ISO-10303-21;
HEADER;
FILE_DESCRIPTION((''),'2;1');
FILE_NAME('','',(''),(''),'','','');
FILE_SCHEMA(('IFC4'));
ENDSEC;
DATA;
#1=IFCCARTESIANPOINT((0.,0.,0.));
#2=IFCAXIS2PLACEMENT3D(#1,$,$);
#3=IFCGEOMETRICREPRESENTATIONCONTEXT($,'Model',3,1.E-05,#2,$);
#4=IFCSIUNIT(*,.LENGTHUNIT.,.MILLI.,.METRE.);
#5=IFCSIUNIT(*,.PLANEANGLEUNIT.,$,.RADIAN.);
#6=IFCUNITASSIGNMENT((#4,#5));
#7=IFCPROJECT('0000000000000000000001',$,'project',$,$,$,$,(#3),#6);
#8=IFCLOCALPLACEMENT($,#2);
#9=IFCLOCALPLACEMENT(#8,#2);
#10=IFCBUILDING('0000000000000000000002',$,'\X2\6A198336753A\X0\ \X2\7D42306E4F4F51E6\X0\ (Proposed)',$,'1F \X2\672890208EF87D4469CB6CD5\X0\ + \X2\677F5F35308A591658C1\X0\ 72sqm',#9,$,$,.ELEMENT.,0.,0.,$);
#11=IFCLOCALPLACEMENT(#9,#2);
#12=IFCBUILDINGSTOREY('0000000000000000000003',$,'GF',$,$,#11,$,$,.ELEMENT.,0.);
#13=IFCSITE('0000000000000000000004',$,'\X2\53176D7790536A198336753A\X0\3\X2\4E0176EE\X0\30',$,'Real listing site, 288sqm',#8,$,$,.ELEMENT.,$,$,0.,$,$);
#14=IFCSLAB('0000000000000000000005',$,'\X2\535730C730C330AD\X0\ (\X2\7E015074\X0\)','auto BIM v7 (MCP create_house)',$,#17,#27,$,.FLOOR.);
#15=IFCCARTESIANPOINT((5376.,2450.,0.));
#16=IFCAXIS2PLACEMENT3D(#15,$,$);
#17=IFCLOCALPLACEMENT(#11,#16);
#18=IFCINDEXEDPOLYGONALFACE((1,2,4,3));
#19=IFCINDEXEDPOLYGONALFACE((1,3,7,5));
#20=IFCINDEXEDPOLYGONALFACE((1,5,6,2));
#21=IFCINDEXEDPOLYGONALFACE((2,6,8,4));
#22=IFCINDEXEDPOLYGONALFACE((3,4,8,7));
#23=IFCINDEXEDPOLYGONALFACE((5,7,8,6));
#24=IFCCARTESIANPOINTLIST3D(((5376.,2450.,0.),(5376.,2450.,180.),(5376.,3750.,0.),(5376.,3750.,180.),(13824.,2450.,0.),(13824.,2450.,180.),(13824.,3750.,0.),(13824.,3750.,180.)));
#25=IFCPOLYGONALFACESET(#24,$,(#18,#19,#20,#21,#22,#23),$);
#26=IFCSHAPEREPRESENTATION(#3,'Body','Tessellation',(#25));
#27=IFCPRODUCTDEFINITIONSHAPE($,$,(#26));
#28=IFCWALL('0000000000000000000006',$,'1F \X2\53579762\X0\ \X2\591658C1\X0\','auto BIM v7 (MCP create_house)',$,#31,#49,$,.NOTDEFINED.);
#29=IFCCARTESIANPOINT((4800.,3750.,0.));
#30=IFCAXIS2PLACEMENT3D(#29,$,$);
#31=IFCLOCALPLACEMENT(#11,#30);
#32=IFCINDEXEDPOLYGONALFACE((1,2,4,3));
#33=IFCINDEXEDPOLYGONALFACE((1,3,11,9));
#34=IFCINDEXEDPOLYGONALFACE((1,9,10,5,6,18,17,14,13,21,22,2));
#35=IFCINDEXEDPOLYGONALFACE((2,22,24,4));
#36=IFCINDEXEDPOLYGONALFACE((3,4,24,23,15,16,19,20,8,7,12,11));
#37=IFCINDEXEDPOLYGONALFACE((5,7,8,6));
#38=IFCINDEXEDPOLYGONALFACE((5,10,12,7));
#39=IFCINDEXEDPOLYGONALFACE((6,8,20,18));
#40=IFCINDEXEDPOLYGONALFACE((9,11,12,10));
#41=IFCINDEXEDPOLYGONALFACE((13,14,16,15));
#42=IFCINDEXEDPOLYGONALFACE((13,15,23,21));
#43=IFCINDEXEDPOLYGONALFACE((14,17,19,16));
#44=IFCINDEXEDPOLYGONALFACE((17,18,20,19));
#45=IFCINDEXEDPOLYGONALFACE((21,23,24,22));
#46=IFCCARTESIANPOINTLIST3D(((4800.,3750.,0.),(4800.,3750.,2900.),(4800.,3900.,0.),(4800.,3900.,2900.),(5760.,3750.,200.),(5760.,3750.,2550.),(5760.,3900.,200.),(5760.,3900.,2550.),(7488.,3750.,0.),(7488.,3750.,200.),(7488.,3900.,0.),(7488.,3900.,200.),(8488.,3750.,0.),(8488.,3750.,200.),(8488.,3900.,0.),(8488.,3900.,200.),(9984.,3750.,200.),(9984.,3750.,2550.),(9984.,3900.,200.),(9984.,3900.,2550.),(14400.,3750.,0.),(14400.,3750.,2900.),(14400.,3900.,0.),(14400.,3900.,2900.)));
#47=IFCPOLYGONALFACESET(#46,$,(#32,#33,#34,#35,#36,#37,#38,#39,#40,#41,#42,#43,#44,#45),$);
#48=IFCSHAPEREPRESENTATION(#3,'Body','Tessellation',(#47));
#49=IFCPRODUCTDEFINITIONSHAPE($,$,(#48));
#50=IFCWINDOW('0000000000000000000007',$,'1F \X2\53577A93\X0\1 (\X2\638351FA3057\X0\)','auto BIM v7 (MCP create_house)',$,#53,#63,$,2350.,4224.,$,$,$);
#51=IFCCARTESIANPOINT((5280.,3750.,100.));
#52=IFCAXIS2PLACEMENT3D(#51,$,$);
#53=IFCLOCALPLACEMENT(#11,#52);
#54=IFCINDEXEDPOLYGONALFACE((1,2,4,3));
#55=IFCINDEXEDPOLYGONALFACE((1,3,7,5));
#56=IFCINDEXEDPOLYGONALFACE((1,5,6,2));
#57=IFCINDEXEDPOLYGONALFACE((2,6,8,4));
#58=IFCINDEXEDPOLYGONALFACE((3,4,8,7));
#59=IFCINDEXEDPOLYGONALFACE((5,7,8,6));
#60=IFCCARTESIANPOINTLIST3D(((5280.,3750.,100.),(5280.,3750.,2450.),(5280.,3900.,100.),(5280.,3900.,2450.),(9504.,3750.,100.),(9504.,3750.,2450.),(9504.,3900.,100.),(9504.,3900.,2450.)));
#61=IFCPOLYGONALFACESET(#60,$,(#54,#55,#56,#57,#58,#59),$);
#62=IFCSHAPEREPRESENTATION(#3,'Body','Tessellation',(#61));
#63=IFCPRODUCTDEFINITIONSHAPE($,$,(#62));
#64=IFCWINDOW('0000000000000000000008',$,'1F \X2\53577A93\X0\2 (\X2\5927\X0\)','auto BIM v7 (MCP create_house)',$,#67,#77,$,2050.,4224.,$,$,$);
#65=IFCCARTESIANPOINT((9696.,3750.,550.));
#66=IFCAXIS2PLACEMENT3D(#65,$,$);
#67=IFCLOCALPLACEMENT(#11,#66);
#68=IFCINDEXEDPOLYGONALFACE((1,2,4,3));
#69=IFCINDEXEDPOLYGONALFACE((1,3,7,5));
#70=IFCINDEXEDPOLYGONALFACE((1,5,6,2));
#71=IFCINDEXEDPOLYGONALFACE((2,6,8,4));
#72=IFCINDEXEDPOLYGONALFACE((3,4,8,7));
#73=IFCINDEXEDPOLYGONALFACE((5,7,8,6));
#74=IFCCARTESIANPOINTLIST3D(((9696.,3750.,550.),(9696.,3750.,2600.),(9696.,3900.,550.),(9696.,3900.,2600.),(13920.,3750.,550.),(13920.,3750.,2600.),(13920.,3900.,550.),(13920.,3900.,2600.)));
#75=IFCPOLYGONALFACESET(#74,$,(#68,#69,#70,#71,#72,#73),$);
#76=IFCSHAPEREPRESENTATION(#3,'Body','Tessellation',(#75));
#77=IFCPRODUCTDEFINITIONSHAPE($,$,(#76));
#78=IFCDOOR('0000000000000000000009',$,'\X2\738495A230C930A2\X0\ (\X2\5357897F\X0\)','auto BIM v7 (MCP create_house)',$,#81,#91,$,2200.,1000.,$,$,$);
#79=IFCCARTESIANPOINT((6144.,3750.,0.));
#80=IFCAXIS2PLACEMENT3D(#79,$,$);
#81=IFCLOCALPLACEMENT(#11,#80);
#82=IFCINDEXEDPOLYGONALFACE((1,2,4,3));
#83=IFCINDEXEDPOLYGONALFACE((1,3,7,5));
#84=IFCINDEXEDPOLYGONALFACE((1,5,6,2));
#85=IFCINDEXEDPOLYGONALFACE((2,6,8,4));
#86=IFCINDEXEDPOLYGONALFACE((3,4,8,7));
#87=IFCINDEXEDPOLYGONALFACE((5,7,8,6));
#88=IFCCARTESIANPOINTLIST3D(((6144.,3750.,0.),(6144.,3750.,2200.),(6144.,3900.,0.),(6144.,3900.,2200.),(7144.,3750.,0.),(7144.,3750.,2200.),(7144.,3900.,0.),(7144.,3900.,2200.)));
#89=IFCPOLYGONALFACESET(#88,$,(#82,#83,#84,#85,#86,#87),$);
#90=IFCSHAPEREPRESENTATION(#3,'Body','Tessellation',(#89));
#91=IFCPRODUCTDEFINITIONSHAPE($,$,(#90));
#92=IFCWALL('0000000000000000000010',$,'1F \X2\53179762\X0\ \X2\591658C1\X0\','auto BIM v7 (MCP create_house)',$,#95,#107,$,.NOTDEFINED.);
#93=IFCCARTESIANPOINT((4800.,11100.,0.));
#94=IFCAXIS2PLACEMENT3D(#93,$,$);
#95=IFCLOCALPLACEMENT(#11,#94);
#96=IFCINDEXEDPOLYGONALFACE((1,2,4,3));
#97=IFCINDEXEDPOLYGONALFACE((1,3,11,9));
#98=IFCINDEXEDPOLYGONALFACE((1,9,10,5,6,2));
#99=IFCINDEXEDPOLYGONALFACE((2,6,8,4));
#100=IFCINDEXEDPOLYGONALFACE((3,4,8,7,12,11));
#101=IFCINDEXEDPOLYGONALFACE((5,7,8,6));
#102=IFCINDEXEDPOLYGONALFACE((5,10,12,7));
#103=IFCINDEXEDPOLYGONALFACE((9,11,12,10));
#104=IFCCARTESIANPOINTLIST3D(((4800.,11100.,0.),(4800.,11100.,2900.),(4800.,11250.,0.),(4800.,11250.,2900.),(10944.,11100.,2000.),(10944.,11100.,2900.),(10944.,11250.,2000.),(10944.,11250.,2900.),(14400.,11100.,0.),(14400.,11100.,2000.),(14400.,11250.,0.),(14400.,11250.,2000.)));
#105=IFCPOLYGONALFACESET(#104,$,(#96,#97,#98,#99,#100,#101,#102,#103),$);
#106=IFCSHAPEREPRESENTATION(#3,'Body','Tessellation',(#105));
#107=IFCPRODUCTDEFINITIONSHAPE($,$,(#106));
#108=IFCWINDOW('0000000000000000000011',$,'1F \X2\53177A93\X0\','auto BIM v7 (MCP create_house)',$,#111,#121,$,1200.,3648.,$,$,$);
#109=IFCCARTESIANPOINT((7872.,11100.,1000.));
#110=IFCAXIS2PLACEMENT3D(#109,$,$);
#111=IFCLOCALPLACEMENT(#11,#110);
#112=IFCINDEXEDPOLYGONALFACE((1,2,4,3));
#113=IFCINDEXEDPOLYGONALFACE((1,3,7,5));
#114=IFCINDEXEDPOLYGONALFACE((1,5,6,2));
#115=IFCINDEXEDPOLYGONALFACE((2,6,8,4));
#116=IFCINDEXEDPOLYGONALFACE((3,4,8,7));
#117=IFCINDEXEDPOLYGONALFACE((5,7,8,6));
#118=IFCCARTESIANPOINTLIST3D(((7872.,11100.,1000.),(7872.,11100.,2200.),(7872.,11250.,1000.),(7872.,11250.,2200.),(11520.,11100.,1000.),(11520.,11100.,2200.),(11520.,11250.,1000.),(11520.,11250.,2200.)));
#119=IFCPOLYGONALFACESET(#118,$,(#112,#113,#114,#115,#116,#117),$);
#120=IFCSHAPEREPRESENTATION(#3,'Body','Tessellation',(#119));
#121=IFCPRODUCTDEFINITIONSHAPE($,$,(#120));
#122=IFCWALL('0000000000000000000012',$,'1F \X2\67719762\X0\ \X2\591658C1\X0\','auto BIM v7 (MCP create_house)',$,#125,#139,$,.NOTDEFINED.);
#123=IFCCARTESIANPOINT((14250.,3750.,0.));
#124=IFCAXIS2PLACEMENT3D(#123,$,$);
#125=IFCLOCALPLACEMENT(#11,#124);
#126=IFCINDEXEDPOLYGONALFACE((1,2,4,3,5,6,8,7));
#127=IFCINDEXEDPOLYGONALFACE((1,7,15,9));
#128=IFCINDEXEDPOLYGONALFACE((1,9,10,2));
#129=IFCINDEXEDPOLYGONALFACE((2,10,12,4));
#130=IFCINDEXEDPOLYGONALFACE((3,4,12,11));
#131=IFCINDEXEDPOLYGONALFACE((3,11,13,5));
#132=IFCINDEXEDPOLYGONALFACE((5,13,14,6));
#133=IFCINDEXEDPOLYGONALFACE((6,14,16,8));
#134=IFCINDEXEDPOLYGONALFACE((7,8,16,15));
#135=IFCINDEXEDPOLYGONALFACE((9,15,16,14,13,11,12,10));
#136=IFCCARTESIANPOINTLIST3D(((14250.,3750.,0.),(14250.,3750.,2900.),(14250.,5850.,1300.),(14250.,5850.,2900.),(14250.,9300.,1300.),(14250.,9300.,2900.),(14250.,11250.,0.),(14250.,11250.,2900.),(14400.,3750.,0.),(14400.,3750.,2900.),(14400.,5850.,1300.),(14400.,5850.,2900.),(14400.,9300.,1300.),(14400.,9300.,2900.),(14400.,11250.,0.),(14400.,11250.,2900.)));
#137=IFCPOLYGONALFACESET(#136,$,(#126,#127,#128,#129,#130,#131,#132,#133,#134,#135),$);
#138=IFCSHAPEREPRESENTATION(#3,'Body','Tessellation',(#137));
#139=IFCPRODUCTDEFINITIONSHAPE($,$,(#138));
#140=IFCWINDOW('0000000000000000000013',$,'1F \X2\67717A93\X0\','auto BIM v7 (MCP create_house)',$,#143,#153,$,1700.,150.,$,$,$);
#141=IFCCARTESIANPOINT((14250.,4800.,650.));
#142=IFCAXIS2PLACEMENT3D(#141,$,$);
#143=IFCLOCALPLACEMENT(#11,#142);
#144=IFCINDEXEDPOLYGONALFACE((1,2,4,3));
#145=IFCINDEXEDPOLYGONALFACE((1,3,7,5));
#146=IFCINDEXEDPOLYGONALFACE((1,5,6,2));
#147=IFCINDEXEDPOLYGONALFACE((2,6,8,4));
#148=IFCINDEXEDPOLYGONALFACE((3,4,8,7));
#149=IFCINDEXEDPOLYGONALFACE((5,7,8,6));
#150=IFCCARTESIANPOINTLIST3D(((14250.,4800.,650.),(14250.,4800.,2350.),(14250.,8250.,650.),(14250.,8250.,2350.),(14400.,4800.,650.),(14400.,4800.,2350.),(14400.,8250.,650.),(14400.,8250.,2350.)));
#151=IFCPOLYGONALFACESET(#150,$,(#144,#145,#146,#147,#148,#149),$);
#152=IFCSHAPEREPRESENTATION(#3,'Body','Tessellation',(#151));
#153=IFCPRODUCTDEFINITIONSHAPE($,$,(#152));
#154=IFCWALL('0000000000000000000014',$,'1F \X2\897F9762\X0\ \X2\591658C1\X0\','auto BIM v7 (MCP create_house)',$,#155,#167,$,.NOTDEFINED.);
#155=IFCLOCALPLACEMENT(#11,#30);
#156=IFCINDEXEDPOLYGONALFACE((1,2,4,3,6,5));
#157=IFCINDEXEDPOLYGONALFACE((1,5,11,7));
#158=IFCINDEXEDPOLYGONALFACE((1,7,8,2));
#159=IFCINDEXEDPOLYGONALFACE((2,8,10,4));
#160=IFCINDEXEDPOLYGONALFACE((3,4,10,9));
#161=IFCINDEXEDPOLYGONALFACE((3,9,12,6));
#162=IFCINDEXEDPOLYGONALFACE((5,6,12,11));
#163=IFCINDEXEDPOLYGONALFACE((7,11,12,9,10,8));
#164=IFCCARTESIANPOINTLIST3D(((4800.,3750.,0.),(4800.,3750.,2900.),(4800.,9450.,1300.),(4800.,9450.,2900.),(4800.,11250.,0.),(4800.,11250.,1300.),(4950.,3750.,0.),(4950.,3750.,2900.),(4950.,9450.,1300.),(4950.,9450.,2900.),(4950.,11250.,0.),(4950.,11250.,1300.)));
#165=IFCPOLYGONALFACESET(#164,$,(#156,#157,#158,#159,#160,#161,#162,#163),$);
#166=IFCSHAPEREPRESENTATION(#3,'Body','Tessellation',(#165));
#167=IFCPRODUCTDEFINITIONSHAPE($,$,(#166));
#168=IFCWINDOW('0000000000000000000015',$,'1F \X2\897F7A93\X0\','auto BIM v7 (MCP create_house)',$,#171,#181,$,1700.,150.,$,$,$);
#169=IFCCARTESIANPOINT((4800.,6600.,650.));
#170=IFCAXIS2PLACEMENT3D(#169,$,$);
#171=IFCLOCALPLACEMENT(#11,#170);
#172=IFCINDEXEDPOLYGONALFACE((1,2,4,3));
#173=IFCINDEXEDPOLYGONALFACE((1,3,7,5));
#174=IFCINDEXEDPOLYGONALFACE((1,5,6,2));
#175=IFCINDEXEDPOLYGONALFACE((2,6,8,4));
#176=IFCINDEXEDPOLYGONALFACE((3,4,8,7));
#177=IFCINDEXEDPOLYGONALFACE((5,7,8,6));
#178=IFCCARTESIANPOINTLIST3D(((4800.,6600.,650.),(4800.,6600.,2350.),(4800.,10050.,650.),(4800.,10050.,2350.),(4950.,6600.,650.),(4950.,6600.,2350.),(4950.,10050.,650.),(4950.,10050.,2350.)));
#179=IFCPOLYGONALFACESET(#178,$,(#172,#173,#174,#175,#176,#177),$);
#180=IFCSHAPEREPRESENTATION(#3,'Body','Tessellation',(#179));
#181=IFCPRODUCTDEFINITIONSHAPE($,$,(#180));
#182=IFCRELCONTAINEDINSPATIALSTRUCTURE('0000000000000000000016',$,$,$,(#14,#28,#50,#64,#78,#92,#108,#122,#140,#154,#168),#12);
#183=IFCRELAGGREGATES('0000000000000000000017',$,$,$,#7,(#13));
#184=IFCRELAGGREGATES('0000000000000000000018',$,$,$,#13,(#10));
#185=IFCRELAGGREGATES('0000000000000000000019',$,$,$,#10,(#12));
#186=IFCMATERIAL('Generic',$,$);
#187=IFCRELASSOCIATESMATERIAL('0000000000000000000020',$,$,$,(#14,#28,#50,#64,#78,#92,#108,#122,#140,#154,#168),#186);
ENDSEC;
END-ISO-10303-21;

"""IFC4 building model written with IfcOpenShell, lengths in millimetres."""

from ifc_helpers import new_model, si_unit, frame, frame_2d, origin, place, context, project, spatial, rectangle, extrude, material, element, fill, save


model = new_model("IFC4")

# Units and contexts
model_context = context("Model", 3, precision=1e-05, world=origin())
ifc_project = project(units=[si_unit("LENGTHUNIT", "METRE", prefix="MILLI"), si_unit("PLANEANGLEUNIT", "RADIAN")], contexts=[model_context])

# Site, building, storey
site_placement = place(None, origin())
site = spatial("IfcSite", under=ifc_project, at=site_placement, Name="北海道標茶町3丁目30", ObjectType="Real listing site, 288sqm", CompositionType="ELEMENT", RefElevation=0.0)
building_placement = place(site_placement, origin())
building = spatial("IfcBuilding", under=site, at=building_placement, Name="標茶町 終の住処 (Proposed)", ObjectType="1F 木造軸組構法 + 板張り外壁 72sqm", CompositionType="ELEMENT", ElevationOfRefHeight=0.0, ElevationOfTerrain=0.0)
storey_placement = place(building_placement, origin())
storey = spatial("IfcBuildingStorey", under=building, at=storey_placement, Name="GF", CompositionType="ELEMENT", Elevation=0.0)

# Slab
ifc_material = material(Name="Generic")
slab_1_placement = place(storey_placement, frame((5376.0, 2450.0, 0.0)))
element("IfcSlab", 1, at=slab_1_placement, inside=storey, material=ifc_material, Name="南デッキ (縁側)", Description="auto BIM v7 (MCP create_house)", PredefinedType="FLOOR", context=model_context, shape_type="SweptSolid", body=[
    extrude(rectangle(XDim=8448.0, YDim=1300.0, at=frame_2d((4224.0, 650.0))), frame((5376.0, 2450.0, 0.0)), (0.0, 0.0, 1.0), 180.0),
])

# Wall, openings, windows, door
wall_1_placement = place(storey_placement, frame((4800.0, 3750.0, 0.0)))
wall_1 = element("IfcWall", 2, at=wall_1_placement, inside=storey, material=ifc_material, Name="1F 南面 外壁", Description="auto BIM v7 (MCP create_house)", PredefinedType="NOTDEFINED", context=model_context, shape_type="SweptSolid", body=[
    extrude(rectangle(XDim=9600.0, YDim=150.0, at=frame_2d((4800.0, 75.0))), frame((4800.0, 3750.0, 0.0)), (0.0, 0.0, 1.0), 2900.0),
])
opening_1_placement = place(storey_placement, frame((5280.0, 3750.0, 100.0)))
opening_1 = element("IfcOpeningElement", 3, at=opening_1_placement, cuts=wall_1, PredefinedType="NOTDEFINED", context=model_context, shape_type="SweptSolid", body=[
    extrude(rectangle(XDim=4224.0, YDim=150.0, at=frame_2d((2112.0, 75.0))), frame((5280.0, 3750.0, 100.0)), (0.0, 0.0, 1.0), 2350.0),
])
opening_2_placement = place(storey_placement, frame((9696.0, 3750.0, 550.0)))
opening_2 = element("IfcOpeningElement", 4, at=opening_2_placement, cuts=wall_1, PredefinedType="NOTDEFINED", context=model_context, shape_type="SweptSolid", body=[
    extrude(rectangle(XDim=4224.0, YDim=150.0, at=frame_2d((2112.0, 75.0))), frame((9696.0, 3750.0, 550.0)), (0.0, 0.0, 1.0), 2050.0),
])
opening_3_placement = place(storey_placement, frame((6144.0, 3750.0, 0.0)))
opening_3 = element("IfcOpeningElement", 5, at=opening_3_placement, cuts=wall_1, PredefinedType="NOTDEFINED", context=model_context, shape_type="SweptSolid", body=[
    extrude(rectangle(XDim=1000.0, YDim=150.0, at=frame_2d((500.0, 75.0))), frame((6144.0, 3750.0, 0.0)), (0.0, 0.0, 1.0), 2200.0),
])
window_1_placement = place(storey_placement, frame((5280.0, 3750.0, 100.0)))
window_1 = element("IfcWindow", 6, at=window_1_placement, inside=storey, material=ifc_material, Name="1F 南窓1 (掃出し)", Description="auto BIM v7 (MCP create_house)", OverallHeight=2350.0, OverallWidth=4224.0, context=model_context, shape_type="SweptSolid", body=[
    extrude(rectangle(XDim=4224.0, YDim=150.0, at=frame_2d((2112.0, 75.0))), frame((5280.0, 3750.0, 100.0)), (0.0, 0.0, 1.0), 2350.0),
])
fill(opening_1, window_1)
window_2_placement = place(storey_placement, frame((9696.0, 3750.0, 550.0)))
window_2 = element("IfcWindow", 7, at=window_2_placement, inside=storey, material=ifc_material, Name="1F 南窓2 (大)", Description="auto BIM v7 (MCP create_house)", OverallHeight=2050.0, OverallWidth=4224.0, context=model_context, shape_type="SweptSolid", body=[
    extrude(rectangle(XDim=4224.0, YDim=150.0, at=frame_2d((2112.0, 75.0))), frame((9696.0, 3750.0, 550.0)), (0.0, 0.0, 1.0), 2050.0),
])
fill(opening_2, window_2)
door_placement = place(storey_placement, frame((6144.0, 3750.0, 0.0)))
door = element("IfcDoor", 8, at=door_placement, inside=storey, material=ifc_material, Name="玄関ドア (南西)", Description="auto BIM v7 (MCP create_house)", OverallHeight=2200.0, OverallWidth=1000.0, context=model_context, shape_type="SweptSolid", body=[
    extrude(rectangle(XDim=1000.0, YDim=150.0, at=frame_2d((500.0, 75.0))), frame((6144.0, 3750.0, 0.0)), (0.0, 0.0, 1.0), 2200.0),
])
fill(opening_3, door)

# Walls, openings, windows
wall_2_placement = place(storey_placement, frame((4800.0, 11100.0, 0.0)))
wall_2 = element("IfcWall", 9, at=wall_2_placement, inside=storey, material=ifc_material, Name="1F 北面 外壁", Description="auto BIM v7 (MCP create_house)", PredefinedType="NOTDEFINED", context=model_context, shape_type="SweptSolid", body=[
    extrude(rectangle(XDim=9600.0, YDim=150.0, at=frame_2d((4800.0, 75.0))), frame((4800.0, 11100.0, 0.0)), (0.0, 0.0, 1.0), 2900.0),
])
opening_4_placement = place(storey_placement, frame((7872.0, 11100.0, 1000.0)))
opening_4 = element("IfcOpeningElement", 10, at=opening_4_placement, cuts=wall_2, PredefinedType="NOTDEFINED", context=model_context, shape_type="SweptSolid", body=[
    extrude(rectangle(XDim=3648.0, YDim=150.0, at=frame_2d((1824.0, 75.0))), frame((7872.0, 11100.0, 1000.0)), (0.0, 0.0, 1.0), 1200.0),
])
window_3_placement = place(storey_placement, frame((7872.0, 11100.0, 1000.0)))
window_3 = element("IfcWindow", 11, at=window_3_placement, inside=storey, material=ifc_material, Name="1F 北窓", Description="auto BIM v7 (MCP create_house)", OverallHeight=1200.0, OverallWidth=3648.0, context=model_context, shape_type="SweptSolid", body=[
    extrude(rectangle(XDim=3648.0, YDim=150.0, at=frame_2d((1824.0, 75.0))), frame((7872.0, 11100.0, 1000.0)), (0.0, 0.0, 1.0), 1200.0),
])
fill(opening_4, window_3)
wall_3_placement = place(storey_placement, frame((14250.0, 3750.0, 0.0)))
wall_3 = element("IfcWall", 12, at=wall_3_placement, inside=storey, material=ifc_material, Name="1F 東面 外壁", Description="auto BIM v7 (MCP create_house)", PredefinedType="NOTDEFINED", context=model_context, shape_type="SweptSolid", body=[
    extrude(rectangle(XDim=150.0, YDim=7500.0, at=frame_2d((75.0, 3750.0))), frame((14250.0, 3750.0, 0.0)), (0.0, 0.0, 1.0), 2900.0),
])
opening_5_placement = place(storey_placement, frame((14250.0, 4800.0, 650.0)))
opening_5 = element("IfcOpeningElement", 13, at=opening_5_placement, cuts=wall_3, PredefinedType="NOTDEFINED", context=model_context, shape_type="SweptSolid", body=[
    extrude(rectangle(XDim=150.0, YDim=3450.0, at=frame_2d((75.0, 1725.0))), frame((14250.0, 4800.0, 650.0)), (0.0, 0.0, 1.0), 1700.0),
])
window_4_placement = place(storey_placement, frame((14250.0, 4800.0, 650.0)))
window_4 = element("IfcWindow", 14, at=window_4_placement, inside=storey, material=ifc_material, Name="1F 東窓", Description="auto BIM v7 (MCP create_house)", OverallHeight=1700.0, OverallWidth=150.0, context=model_context, shape_type="SweptSolid", body=[
    extrude(rectangle(XDim=150.0, YDim=3450.0, at=frame_2d((75.0, 1725.0))), frame((14250.0, 4800.0, 650.0)), (0.0, 0.0, 1.0), 1700.0),
])
fill(opening_5, window_4)
wall_4_placement = place(storey_placement, frame((4800.0, 3750.0, 0.0)))
wall_4 = element("IfcWall", 15, at=wall_4_placement, inside=storey, material=ifc_material, Name="1F 西面 外壁", Description="auto BIM v7 (MCP create_house)", PredefinedType="NOTDEFINED", context=model_context, shape_type="SweptSolid", body=[
    extrude(rectangle(XDim=150.0, YDim=7500.0, at=frame_2d((75.0, 3750.0))), frame((4800.0, 3750.0, 0.0)), (0.0, 0.0, 1.0), 2900.0),
])
opening_6_placement = place(storey_placement, frame((4800.0, 6600.0, 650.0)))
opening_6 = element("IfcOpeningElement", 16, at=opening_6_placement, cuts=wall_4, PredefinedType="NOTDEFINED", context=model_context, shape_type="SweptSolid", body=[
    extrude(rectangle(XDim=150.0, YDim=3450.0, at=frame_2d((75.0, 1725.0))), frame((4800.0, 6600.0, 650.0)), (0.0, 0.0, 1.0), 1700.0),
])
window_5_placement = place(storey_placement, frame((4800.0, 6600.0, 650.0)))
window_5 = element("IfcWindow", 17, at=window_5_placement, inside=storey, material=ifc_material, Name="1F 西窓", Description="auto BIM v7 (MCP create_house)", OverallHeight=1700.0, OverallWidth=150.0, context=model_context, shape_type="SweptSolid", body=[
    extrude(rectangle(XDim=150.0, YDim=3450.0, at=frame_2d((75.0, 1725.0))), frame((4800.0, 6600.0, 650.0)), (0.0, 0.0, 1.0), 1700.0),
])
fill(opening_6, window_5)

save(model, "model.ifc")
